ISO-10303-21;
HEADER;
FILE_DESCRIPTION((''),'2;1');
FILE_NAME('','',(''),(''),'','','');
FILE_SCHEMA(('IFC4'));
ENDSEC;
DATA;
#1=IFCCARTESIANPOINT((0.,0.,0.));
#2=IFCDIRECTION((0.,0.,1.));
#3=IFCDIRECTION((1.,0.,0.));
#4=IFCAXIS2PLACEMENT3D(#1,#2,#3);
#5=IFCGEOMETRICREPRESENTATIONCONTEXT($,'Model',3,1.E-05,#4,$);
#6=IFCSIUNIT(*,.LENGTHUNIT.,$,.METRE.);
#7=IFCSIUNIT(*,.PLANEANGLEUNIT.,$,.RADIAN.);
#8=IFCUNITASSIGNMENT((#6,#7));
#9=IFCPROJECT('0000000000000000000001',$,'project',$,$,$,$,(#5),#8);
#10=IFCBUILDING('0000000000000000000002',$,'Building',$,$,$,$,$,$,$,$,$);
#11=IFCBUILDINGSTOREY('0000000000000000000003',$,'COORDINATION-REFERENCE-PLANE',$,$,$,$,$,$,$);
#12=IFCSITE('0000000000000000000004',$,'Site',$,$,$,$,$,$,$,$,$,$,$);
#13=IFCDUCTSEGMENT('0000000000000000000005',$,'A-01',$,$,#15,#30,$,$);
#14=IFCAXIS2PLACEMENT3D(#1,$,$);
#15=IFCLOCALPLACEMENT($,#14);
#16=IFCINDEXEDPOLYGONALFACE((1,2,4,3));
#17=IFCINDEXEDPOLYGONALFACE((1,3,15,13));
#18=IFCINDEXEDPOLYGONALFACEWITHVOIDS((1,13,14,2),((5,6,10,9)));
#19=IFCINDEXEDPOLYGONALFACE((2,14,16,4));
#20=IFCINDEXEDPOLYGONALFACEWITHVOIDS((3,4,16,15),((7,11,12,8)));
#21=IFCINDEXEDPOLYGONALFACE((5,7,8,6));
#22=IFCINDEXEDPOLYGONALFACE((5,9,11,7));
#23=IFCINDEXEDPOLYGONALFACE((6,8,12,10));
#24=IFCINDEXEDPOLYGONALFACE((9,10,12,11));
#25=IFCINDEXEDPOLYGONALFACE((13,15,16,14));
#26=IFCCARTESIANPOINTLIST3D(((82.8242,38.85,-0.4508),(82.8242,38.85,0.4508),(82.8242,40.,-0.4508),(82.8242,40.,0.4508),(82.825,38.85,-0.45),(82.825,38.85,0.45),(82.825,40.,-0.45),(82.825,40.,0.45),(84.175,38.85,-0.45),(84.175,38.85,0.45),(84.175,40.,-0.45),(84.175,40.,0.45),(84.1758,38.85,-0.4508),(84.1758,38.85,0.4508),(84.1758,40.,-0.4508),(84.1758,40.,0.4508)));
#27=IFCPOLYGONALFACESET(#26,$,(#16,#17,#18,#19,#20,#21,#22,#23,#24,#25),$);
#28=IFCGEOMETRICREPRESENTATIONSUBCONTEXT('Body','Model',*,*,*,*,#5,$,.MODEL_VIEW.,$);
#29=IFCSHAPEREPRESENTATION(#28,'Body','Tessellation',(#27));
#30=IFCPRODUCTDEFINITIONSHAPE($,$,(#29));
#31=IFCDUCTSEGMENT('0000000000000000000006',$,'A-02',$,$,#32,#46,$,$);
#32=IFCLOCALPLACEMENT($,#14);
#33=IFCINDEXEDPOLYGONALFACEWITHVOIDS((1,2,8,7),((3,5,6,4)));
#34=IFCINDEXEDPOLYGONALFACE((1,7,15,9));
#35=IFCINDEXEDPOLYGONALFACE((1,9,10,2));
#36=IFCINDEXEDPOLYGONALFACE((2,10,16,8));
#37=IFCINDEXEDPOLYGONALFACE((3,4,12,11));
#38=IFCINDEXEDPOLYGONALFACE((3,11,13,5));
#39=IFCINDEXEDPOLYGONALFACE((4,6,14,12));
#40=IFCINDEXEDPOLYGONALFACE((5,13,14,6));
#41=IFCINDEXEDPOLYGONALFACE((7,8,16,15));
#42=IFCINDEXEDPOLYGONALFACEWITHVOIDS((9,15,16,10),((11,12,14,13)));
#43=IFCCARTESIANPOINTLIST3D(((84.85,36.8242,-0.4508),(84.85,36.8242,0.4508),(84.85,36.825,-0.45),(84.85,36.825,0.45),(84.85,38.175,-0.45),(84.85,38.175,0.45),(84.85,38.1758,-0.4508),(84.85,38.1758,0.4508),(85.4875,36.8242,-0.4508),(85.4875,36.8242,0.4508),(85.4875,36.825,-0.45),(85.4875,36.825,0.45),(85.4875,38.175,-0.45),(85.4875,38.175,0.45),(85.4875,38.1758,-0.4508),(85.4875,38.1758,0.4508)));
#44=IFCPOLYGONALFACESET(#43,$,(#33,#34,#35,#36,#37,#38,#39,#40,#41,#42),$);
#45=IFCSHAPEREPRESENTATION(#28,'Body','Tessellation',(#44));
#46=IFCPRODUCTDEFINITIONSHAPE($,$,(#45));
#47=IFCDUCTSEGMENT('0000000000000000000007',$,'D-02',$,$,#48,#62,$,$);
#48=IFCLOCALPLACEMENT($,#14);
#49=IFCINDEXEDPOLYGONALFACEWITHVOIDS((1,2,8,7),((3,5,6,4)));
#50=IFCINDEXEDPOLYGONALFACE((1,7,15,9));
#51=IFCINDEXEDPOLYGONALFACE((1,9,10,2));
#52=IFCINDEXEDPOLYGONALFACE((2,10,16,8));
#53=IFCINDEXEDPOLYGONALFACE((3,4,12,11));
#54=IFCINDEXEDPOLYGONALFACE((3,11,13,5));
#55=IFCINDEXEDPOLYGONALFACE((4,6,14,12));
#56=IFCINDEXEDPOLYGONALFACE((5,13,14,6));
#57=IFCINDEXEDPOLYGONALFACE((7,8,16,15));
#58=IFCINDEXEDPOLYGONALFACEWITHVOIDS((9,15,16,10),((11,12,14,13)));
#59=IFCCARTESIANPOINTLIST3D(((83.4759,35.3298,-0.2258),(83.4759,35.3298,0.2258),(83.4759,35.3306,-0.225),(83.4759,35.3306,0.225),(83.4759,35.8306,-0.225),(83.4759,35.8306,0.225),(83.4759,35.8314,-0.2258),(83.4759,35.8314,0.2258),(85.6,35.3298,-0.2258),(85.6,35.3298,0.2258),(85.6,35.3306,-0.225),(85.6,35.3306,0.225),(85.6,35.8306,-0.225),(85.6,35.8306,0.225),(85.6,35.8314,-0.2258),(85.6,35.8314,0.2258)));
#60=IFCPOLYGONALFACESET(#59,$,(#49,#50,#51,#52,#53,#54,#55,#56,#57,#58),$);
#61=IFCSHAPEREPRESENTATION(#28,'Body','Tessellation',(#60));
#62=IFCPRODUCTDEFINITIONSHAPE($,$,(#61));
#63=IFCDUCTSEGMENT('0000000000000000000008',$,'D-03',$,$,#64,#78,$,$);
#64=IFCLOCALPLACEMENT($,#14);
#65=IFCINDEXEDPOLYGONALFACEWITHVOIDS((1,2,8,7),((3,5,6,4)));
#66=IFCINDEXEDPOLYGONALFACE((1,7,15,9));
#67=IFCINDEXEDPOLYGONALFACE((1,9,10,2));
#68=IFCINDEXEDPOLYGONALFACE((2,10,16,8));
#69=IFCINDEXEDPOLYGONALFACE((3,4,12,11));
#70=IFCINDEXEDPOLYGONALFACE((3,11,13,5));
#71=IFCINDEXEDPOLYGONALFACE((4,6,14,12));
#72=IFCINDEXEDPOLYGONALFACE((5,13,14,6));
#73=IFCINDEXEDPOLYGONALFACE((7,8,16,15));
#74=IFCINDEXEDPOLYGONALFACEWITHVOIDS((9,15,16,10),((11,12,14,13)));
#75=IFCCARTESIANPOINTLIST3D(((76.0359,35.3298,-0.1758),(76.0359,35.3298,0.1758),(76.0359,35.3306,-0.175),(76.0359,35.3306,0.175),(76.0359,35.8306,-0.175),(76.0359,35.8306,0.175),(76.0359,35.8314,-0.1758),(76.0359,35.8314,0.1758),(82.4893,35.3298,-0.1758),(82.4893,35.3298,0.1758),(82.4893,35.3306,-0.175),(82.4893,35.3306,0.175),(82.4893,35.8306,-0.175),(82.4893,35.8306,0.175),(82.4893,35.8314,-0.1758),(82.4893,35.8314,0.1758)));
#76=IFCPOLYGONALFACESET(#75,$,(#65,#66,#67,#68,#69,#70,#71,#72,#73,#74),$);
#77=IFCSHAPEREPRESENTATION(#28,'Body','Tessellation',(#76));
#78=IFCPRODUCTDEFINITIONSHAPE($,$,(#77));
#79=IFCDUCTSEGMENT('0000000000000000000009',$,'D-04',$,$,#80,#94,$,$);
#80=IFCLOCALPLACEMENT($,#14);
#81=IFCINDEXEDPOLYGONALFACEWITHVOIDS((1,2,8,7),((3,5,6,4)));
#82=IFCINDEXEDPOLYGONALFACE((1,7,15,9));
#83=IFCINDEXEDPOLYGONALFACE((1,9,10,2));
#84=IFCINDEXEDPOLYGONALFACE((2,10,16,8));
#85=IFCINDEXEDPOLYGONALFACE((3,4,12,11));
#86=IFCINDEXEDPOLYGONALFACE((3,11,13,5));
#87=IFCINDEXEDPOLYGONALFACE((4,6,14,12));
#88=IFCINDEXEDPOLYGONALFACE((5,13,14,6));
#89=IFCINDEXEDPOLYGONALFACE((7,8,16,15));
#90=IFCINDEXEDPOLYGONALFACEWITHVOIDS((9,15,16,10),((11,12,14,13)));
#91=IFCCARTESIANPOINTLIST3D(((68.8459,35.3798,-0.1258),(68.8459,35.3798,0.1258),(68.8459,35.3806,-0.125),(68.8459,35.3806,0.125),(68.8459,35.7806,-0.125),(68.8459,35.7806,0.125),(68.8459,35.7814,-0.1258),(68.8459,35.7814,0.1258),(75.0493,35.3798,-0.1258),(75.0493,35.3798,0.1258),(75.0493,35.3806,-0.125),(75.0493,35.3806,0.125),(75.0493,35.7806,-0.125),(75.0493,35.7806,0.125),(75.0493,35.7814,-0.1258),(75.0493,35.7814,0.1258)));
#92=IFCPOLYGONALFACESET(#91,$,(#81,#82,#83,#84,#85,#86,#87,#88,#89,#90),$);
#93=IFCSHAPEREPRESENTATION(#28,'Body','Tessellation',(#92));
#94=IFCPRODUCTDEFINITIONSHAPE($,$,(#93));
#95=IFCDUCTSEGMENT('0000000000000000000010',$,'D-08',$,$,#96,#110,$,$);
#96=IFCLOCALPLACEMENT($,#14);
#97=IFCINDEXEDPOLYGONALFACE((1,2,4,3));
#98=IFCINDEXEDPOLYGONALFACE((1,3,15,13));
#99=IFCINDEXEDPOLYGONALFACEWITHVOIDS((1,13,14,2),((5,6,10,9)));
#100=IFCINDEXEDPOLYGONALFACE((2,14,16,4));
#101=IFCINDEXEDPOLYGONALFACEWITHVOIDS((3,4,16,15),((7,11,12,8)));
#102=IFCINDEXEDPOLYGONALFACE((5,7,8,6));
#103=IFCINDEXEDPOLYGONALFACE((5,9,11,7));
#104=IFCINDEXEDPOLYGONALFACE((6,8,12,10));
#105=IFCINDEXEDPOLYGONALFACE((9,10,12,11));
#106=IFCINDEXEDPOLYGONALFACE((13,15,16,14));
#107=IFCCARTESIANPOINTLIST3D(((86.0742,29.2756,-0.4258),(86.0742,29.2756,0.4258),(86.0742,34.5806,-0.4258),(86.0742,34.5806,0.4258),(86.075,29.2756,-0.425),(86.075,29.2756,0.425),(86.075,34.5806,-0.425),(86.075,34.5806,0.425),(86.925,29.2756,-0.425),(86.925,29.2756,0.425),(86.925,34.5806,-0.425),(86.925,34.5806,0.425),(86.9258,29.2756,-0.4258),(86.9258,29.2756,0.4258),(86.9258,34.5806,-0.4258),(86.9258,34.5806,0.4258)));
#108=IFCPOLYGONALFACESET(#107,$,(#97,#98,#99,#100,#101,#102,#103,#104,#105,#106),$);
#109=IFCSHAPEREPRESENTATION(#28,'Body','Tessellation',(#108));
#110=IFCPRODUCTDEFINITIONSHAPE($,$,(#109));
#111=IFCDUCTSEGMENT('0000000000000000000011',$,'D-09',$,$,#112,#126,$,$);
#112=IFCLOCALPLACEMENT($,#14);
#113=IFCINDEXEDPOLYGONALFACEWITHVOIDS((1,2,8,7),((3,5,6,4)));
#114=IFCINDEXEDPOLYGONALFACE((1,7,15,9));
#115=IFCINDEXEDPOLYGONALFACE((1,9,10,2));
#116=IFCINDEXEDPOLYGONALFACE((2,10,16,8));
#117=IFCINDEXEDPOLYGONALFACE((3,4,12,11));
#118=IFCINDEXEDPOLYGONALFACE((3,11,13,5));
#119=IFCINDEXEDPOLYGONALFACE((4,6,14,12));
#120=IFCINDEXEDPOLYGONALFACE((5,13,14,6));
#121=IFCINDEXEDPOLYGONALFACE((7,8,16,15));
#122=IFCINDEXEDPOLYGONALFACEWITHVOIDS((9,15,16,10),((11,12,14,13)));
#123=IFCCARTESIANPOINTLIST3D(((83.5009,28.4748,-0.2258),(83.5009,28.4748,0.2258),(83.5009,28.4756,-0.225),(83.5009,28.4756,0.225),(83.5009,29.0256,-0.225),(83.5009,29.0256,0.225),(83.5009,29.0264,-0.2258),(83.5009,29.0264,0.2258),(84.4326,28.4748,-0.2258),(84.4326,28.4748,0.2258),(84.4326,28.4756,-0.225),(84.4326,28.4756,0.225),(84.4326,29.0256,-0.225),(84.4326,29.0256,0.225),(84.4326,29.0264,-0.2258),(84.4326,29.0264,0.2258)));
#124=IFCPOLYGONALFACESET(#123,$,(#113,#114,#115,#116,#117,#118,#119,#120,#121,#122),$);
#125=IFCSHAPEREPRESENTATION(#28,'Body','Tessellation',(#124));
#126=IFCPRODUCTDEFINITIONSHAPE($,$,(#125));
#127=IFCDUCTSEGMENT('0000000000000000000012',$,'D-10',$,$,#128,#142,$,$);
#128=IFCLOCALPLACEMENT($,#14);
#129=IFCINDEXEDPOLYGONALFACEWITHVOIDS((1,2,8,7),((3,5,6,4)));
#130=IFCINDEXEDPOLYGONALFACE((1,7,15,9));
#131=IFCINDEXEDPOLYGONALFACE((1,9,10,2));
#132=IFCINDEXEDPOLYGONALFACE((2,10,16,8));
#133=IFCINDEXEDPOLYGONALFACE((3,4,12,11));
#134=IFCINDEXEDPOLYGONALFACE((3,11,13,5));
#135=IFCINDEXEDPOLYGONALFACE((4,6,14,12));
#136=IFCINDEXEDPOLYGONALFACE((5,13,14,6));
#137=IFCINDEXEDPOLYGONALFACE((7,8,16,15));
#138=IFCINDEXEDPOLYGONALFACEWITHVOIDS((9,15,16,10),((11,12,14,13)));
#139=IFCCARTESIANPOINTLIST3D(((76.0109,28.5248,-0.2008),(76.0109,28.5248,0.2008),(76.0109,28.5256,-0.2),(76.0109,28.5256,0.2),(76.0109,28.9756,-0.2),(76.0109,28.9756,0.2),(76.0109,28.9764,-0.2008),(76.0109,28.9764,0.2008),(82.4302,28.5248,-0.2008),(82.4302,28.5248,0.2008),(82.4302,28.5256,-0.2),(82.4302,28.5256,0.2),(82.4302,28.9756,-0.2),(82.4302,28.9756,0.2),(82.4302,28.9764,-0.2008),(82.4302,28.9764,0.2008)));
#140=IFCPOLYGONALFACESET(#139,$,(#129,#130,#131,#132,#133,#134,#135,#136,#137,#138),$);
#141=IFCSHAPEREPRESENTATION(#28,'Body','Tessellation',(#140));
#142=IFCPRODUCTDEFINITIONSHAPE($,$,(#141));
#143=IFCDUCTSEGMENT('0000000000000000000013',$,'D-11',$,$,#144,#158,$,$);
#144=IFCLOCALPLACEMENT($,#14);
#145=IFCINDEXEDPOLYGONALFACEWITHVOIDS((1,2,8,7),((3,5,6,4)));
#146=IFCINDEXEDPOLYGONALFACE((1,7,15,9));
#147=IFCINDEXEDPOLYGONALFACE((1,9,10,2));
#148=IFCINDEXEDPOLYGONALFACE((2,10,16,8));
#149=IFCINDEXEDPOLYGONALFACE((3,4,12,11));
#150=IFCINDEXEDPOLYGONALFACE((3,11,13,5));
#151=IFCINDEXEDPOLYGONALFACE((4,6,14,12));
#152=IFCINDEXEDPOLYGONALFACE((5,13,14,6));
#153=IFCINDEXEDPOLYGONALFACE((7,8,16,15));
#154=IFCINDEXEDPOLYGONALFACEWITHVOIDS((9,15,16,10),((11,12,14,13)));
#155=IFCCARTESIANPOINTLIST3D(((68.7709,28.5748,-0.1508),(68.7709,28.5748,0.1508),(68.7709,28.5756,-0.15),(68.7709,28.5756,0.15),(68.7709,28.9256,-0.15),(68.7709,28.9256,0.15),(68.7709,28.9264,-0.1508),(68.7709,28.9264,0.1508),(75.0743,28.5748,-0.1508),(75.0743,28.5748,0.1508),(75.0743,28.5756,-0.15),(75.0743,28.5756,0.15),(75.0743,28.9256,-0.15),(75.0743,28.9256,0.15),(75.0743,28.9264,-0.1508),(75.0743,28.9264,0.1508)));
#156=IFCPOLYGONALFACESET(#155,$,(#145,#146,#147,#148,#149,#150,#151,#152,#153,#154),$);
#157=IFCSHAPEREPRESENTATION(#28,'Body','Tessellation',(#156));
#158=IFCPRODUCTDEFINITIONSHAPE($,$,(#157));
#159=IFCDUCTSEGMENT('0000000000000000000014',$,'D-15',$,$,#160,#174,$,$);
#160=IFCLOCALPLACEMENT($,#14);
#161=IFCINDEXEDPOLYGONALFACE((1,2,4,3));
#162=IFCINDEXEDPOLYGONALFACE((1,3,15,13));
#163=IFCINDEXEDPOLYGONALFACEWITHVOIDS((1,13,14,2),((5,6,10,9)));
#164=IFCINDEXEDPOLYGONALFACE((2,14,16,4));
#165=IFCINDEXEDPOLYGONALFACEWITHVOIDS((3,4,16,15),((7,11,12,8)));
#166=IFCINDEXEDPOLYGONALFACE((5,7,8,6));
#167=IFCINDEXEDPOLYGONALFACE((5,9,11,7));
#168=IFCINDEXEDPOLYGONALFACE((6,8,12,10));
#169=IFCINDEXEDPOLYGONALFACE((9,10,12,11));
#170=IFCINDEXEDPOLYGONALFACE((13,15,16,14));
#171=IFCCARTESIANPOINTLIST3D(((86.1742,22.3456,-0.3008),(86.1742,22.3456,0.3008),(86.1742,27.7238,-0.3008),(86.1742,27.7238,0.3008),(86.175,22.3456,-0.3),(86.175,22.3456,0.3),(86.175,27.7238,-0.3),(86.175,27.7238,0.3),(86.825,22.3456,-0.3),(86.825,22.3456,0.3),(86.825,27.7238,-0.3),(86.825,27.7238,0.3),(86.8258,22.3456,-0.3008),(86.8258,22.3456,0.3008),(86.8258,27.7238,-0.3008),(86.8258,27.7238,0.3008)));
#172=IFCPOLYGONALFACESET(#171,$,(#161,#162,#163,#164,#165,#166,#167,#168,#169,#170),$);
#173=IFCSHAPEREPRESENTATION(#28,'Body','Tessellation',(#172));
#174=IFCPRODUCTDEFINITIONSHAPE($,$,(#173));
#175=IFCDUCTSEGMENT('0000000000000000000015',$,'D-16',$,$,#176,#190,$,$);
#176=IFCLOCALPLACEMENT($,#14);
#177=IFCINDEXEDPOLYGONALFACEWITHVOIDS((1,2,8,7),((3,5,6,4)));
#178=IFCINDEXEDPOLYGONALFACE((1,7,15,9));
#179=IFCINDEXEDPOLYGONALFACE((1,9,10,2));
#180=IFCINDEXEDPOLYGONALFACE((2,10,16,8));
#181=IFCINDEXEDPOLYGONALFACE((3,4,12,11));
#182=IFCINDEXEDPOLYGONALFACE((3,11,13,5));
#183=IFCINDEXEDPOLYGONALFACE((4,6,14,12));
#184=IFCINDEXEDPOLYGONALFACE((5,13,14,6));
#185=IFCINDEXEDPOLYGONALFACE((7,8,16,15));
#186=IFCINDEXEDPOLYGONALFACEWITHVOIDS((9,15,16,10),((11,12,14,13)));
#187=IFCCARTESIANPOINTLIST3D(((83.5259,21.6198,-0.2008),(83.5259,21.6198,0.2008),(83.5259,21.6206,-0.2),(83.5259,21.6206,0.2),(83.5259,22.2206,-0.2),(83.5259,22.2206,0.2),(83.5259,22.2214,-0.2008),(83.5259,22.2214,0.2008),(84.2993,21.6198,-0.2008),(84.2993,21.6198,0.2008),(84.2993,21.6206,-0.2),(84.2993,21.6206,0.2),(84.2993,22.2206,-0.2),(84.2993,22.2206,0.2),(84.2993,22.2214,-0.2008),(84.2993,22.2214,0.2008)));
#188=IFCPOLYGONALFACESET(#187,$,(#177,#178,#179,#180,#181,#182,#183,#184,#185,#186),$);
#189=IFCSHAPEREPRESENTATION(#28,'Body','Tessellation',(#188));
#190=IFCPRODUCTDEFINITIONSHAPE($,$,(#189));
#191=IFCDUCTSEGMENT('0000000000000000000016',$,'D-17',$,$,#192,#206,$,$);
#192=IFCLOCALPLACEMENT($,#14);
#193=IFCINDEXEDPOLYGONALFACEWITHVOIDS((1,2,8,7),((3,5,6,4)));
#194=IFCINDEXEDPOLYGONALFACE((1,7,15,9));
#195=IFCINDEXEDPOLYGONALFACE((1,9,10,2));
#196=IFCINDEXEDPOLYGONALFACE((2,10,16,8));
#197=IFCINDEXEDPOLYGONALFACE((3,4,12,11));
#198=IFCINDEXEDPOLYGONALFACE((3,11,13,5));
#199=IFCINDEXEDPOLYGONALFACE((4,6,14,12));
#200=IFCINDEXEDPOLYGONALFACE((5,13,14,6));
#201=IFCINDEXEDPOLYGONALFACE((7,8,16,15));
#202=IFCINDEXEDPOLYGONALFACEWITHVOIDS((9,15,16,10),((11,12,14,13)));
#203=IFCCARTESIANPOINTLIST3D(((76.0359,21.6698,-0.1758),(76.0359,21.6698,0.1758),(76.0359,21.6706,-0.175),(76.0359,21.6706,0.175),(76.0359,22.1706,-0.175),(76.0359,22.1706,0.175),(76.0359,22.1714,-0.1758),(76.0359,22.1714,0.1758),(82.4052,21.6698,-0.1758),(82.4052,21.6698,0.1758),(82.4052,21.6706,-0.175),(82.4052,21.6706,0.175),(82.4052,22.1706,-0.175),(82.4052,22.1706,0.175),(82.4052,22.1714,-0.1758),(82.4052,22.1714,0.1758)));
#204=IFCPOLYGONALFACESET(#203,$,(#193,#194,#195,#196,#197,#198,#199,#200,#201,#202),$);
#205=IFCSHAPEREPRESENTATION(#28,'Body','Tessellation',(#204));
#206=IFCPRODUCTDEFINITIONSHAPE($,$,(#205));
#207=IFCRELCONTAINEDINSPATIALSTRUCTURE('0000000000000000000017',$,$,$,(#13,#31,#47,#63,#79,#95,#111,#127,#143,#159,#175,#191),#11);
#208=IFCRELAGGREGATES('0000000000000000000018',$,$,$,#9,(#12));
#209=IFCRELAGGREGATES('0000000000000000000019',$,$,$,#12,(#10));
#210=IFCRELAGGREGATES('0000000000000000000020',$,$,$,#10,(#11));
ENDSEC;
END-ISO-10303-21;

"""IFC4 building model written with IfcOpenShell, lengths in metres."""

from ifc_helpers import new_model, si_unit, frame, origin, origin_with_axes, place, context, subcontext, project, spatial, hollow_rectangle, extrude, element, save


model = new_model("IFC4")

# Units and contexts
model_context = context("Model", 3, precision=1e-05, world=origin_with_axes())
body_context = subcontext(model_context, "Body", "Model", "MODEL_VIEW")
ifc_project = project(units=[si_unit("LENGTHUNIT", "METRE"), si_unit("PLANEANGLEUNIT", "RADIAN")], contexts=[model_context])

# Site, building, storey
site = spatial("IfcSite", under=ifc_project, Name="Site")
building = spatial("IfcBuilding", under=site, Name="Building")
storey = spatial("IfcBuildingStorey", under=building, Name="COORDINATION-REFERENCE-PLANE")

# Duct segments
duct_segment_1_placement = place(None, frame((83.5, 38.85, 0.0), z_axis=(0.0, 1.0, 0.0), x_axis=(1.0, 0.0, 0.0)))
element("IfcDuctSegment", 1, at=duct_segment_1_placement, inside=storey, Name="A-01", context=body_context, shape_type="SweptSolid", body=[
    extrude(hollow_rectangle(XDim=1.3516, YDim=0.9016, WallThickness=0.0008), origin(), (0.0, 0.0, 1.0), 1.15),
])
duct_segment_2_placement = place(None, frame((84.85, 37.5, 0.0), z_axis=(1.0, 0.0, 0.0), x_axis=(0.0, 1.0, 0.0)))
element("IfcDuctSegment", 2, at=duct_segment_2_placement, inside=storey, Name="A-02", context=body_context, shape_type="SweptSolid", body=[
    extrude(hollow_rectangle(XDim=1.3516, YDim=0.9016, WallThickness=0.0008), origin(), (0.0, 0.0, 1.0), 0.6375),
])
duct_segment_3_placement = place(None, frame((83.4759, 35.5806, 0.0), z_axis=(1.0, 0.0, 0.0), x_axis=(0.0, 1.0, 0.0)))
element("IfcDuctSegment", 3, at=duct_segment_3_placement, inside=storey, Name="D-02", context=body_context, shape_type="SweptSolid", body=[
    extrude(hollow_rectangle(XDim=0.5016, YDim=0.4516, WallThickness=0.0008), origin(), (0.0, 0.0, 1.0), 2.1241),
])
duct_segment_4_placement = place(None, frame((76.0359, 35.5806, 0.0), z_axis=(1.0, 0.0, 0.0), x_axis=(0.0, 1.0, 0.0)))
element("IfcDuctSegment", 4, at=duct_segment_4_placement, inside=storey, Name="D-03", context=body_context, shape_type="SweptSolid", body=[
    extrude(hollow_rectangle(XDim=0.5016, YDim=0.3516, WallThickness=0.0008), origin(), (0.0, 0.0, 1.0), 6.4534),
])
duct_segment_5_placement = place(None, frame((68.8459, 35.5806, 0.0), z_axis=(1.0, 0.0, 0.0), x_axis=(0.0, 1.0, 0.0)))
element("IfcDuctSegment", 5, at=duct_segment_5_placement, inside=storey, Name="D-04", context=body_context, shape_type="SweptSolid", body=[
    extrude(hollow_rectangle(XDim=0.4016, YDim=0.2516, WallThickness=0.0008), origin(), (0.0, 0.0, 1.0), 6.2034),
])
duct_segment_6_placement = place(None, frame((86.5, 29.2756, 0.0), z_axis=(0.0, 1.0, 0.0), x_axis=(1.0, 0.0, 0.0)))
element("IfcDuctSegment", 6, at=duct_segment_6_placement, inside=storey, Name="D-08", context=body_context, shape_type="SweptSolid", body=[
    extrude(hollow_rectangle(XDim=0.8516, YDim=0.8516, WallThickness=0.0008), origin(), (0.0, 0.0, 1.0), 5.305),
])
duct_segment_7_placement = place(None, frame((83.5009, 28.7506, 0.0), z_axis=(1.0, 0.0, 0.0), x_axis=(0.0, 1.0, 0.0)))
element("IfcDuctSegment", 7, at=duct_segment_7_placement, inside=storey, Name="D-09", context=body_context, shape_type="SweptSolid", body=[
    extrude(hollow_rectangle(XDim=0.5516, YDim=0.4516, WallThickness=0.0008), origin(), (0.0, 0.0, 1.0), 0.9316),
])
duct_segment_8_placement = place(None, frame((76.0109, 28.7506, 0.0), z_axis=(1.0, 0.0, 0.0), x_axis=(0.0, 1.0, 0.0)))
element("IfcDuctSegment", 8, at=duct_segment_8_placement, inside=storey, Name="D-10", context=body_context, shape_type="SweptSolid", body=[
    extrude(hollow_rectangle(XDim=0.4516, YDim=0.4016, WallThickness=0.0008), origin(), (0.0, 0.0, 1.0), 6.4193),
])
duct_segment_9_placement = place(None, frame((68.7709, 28.7506, 0.0), z_axis=(1.0, 0.0, 0.0), x_axis=(0.0, 1.0, 0.0)))
element("IfcDuctSegment", 9, at=duct_segment_9_placement, inside=storey, Name="D-11", context=body_context, shape_type="SweptSolid", body=[
    extrude(hollow_rectangle(XDim=0.3516, YDim=0.3016, WallThickness=0.0008), origin(), (0.0, 0.0, 1.0), 6.3034),
])
duct_segment_10_placement = place(None, frame((86.5, 22.3456, 0.0), z_axis=(0.0, 1.0, 0.0), x_axis=(1.0, 0.0, 0.0)))
element("IfcDuctSegment", 10, at=duct_segment_10_placement, inside=storey, Name="D-15", context=body_context, shape_type="SweptSolid", body=[
    extrude(hollow_rectangle(XDim=0.6516, YDim=0.6016, WallThickness=0.0008), origin(), (0.0, 0.0, 1.0), 5.3782),
])
duct_segment_11_placement = place(None, frame((83.5259, 21.9206, 0.0), z_axis=(1.0, 0.0, 0.0), x_axis=(0.0, 1.0, 0.0)))
element("IfcDuctSegment", 11, at=duct_segment_11_placement, inside=storey, Name="D-16", context=body_context, shape_type="SweptSolid", body=[
    extrude(hollow_rectangle(XDim=0.6016, YDim=0.4016, WallThickness=0.0008), origin(), (0.0, 0.0, 1.0), 0.7733),
])
duct_segment_12_placement = place(None, frame((76.0359, 21.9206, 0.0), z_axis=(1.0, 0.0, 0.0), x_axis=(0.0, 1.0, 0.0)))
element("IfcDuctSegment", 12, at=duct_segment_12_placement, inside=storey, Name="D-17", context=body_context, shape_type="SweptSolid", body=[
    extrude(hollow_rectangle(XDim=0.5016, YDim=0.3516, WallThickness=0.0008), origin(), (0.0, 0.0, 1.0), 6.3693),
])

save(model, "model.ifc")
